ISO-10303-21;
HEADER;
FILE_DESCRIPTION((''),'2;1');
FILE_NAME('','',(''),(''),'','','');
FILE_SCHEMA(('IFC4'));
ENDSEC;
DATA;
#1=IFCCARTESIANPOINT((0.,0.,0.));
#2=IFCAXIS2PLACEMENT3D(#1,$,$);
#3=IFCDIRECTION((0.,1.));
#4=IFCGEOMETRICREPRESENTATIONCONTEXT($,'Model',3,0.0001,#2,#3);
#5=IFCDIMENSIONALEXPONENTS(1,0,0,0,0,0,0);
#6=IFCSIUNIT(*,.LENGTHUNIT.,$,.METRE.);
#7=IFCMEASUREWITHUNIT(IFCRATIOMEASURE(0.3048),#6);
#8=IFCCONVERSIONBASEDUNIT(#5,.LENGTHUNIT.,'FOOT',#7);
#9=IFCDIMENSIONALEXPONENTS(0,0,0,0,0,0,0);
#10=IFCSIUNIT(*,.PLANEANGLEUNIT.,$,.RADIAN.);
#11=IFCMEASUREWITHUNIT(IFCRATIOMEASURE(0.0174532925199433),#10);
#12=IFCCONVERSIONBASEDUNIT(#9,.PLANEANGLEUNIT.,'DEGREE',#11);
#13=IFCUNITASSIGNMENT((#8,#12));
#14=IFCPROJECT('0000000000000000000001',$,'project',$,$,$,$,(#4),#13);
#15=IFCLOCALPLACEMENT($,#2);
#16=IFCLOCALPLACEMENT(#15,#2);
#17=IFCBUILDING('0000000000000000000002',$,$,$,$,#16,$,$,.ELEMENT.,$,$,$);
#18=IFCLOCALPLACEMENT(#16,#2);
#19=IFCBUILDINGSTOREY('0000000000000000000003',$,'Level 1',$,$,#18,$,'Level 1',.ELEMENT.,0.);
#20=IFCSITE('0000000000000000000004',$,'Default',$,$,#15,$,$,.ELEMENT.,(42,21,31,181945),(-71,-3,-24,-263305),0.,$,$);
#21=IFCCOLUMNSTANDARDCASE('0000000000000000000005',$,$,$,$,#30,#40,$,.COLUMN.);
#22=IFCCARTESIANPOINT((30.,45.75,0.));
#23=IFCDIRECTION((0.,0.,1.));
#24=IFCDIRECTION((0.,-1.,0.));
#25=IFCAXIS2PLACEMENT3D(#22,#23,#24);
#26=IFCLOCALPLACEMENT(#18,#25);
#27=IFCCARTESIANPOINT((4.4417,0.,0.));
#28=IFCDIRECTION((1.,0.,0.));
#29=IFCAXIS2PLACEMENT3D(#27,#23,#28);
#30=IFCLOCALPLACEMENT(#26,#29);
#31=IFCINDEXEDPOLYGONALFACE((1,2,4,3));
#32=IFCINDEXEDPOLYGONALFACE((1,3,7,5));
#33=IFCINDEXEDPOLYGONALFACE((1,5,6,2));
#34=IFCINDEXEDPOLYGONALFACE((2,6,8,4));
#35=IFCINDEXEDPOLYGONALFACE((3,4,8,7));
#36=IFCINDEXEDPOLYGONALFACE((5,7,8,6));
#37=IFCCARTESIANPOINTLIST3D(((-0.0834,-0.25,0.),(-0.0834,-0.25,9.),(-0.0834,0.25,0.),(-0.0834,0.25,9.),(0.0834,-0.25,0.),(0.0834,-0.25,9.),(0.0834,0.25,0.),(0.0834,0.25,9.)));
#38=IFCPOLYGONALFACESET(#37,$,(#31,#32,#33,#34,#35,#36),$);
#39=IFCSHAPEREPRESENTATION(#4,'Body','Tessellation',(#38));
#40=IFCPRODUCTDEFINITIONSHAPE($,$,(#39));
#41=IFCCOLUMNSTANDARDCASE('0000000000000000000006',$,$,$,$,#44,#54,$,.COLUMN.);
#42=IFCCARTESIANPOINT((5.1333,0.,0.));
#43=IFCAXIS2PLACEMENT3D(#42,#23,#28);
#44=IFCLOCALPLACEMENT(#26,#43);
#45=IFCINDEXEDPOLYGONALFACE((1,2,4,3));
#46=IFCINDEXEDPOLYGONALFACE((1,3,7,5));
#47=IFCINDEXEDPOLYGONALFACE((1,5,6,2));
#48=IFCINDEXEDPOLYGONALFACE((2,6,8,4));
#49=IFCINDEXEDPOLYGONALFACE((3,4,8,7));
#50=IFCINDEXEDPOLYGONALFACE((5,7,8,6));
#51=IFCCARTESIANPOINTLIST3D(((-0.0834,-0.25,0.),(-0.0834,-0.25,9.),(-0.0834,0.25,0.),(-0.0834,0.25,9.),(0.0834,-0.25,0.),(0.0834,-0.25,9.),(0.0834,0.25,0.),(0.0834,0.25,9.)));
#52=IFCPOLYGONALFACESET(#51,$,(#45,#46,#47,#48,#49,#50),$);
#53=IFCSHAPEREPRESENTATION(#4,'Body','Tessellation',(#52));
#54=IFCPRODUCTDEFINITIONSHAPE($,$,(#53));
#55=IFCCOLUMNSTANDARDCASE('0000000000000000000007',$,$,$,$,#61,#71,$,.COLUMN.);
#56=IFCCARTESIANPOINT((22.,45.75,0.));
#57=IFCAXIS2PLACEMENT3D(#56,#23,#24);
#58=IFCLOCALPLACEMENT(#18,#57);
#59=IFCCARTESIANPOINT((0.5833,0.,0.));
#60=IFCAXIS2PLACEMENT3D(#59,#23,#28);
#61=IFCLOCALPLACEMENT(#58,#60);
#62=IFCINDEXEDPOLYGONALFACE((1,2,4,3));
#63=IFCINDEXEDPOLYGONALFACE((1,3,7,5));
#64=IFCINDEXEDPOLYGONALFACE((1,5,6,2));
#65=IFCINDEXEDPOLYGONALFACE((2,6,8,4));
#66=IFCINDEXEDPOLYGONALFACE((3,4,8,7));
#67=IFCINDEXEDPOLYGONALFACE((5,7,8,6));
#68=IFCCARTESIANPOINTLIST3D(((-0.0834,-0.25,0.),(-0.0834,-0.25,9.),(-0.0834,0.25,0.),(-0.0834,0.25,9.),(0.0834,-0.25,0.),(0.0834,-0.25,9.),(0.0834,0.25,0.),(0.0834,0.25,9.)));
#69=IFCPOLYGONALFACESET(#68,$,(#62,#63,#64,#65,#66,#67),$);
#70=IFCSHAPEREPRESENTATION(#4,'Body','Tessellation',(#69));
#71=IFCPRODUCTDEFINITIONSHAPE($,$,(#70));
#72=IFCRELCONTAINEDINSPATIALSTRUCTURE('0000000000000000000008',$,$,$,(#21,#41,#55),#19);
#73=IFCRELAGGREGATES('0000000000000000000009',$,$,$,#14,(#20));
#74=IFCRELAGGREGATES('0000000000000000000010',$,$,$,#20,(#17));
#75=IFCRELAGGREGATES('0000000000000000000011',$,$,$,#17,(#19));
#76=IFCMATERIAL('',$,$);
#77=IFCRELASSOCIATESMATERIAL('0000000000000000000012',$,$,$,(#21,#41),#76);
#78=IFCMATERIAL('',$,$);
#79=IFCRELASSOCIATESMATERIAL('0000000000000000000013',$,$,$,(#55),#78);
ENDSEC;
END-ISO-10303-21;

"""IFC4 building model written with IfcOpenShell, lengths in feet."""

from ifc_helpers import new_model, entity, si_unit, converted_unit, direction, frame, origin, place, context, project, spatial, rectangle, extrude, material, element, save


model = new_model("IFC4")

# Units and contexts
model_context = context("Model", 3, precision=0.0001, world=origin(), true_north=direction((0.0, 1.0)))
ifc_project = project(units=[converted_unit("LENGTHUNIT", "FOOT", entity("IfcRatioMeasure", 0.3048), si_unit("LENGTHUNIT", "METRE"), dimensions=[1, 0, 0, 0, 0, 0, 0]), converted_unit("PLANEANGLEUNIT", "DEGREE", entity("IfcRatioMeasure", 0.0174532925199433), si_unit("PLANEANGLEUNIT", "RADIAN"), dimensions=[0, 0, 0, 0, 0, 0, 0])], contexts=[model_context])

# Site, building, storey
site_placement = place(None, origin())
site = spatial("IfcSite", under=ifc_project, at=site_placement, Name="Default", CompositionType="ELEMENT", RefLatitude=(42, 21, 31, 181945), RefLongitude=(-71, -3, -24, -263305), RefElevation=0.0)
building_placement = place(site_placement, origin())
building = spatial("IfcBuilding", under=site, at=building_placement, CompositionType="ELEMENT")
storey_placement = place(building_placement, origin())
storey = spatial("IfcBuildingStorey", under=building, at=storey_placement, Name="Level 1", LongName="Level 1", CompositionType="ELEMENT", Elevation=0.0)

# Columns
ifc_material_1 = material(Name="")
placement_1 = place(storey_placement, frame((30.0, 45.75, 0.0), z_axis=(0.0, 0.0, 1.0), x_axis=(0.0, -1.0, 0.0)))
for number, where, z_axis, x_axis in (
    (1, (4.4417, 0.0, 0.0), (0.0, 0.0, 1.0), (1.0, 0.0, 0.0)),
    (2, (5.1333, 0.0, 0.0), (0.0, 0.0, 1.0), (1.0, 0.0, 0.0)),
):
    element("IfcColumnStandardCase", number, at=place(placement_1, frame(where, z_axis=z_axis, x_axis=x_axis)), inside=storey, material=ifc_material_1, PredefinedType="COLUMN", context=model_context, shape_type="SweptSolid", body=[
        extrude(rectangle(XDim=0.1667, YDim=0.5), origin(), (0.0, 0.0, 1.0), 9.0),
    ])
ifc_material_2 = material(Name="")
wall_placement = place(storey_placement, frame((22.0, 45.75, 0.0), z_axis=(0.0, 0.0, 1.0), x_axis=(0.0, -1.0, 0.0)))
for number, where, z_axis, x_axis in (
    (3, (0.5833, 0.0, 0.0), (0.0, 0.0, 1.0), (1.0, 0.0, 0.0)),
):
    element("IfcColumnStandardCase", number, at=place(wall_placement, frame(where, z_axis=z_axis, x_axis=x_axis)), inside=storey, material=ifc_material_2, PredefinedType="COLUMN", context=model_context, shape_type="SweptSolid", body=[
        extrude(rectangle(XDim=0.1667, YDim=0.5), origin(), (0.0, 0.0, 1.0), 9.0),
    ])

save(model, "model.ifc")
